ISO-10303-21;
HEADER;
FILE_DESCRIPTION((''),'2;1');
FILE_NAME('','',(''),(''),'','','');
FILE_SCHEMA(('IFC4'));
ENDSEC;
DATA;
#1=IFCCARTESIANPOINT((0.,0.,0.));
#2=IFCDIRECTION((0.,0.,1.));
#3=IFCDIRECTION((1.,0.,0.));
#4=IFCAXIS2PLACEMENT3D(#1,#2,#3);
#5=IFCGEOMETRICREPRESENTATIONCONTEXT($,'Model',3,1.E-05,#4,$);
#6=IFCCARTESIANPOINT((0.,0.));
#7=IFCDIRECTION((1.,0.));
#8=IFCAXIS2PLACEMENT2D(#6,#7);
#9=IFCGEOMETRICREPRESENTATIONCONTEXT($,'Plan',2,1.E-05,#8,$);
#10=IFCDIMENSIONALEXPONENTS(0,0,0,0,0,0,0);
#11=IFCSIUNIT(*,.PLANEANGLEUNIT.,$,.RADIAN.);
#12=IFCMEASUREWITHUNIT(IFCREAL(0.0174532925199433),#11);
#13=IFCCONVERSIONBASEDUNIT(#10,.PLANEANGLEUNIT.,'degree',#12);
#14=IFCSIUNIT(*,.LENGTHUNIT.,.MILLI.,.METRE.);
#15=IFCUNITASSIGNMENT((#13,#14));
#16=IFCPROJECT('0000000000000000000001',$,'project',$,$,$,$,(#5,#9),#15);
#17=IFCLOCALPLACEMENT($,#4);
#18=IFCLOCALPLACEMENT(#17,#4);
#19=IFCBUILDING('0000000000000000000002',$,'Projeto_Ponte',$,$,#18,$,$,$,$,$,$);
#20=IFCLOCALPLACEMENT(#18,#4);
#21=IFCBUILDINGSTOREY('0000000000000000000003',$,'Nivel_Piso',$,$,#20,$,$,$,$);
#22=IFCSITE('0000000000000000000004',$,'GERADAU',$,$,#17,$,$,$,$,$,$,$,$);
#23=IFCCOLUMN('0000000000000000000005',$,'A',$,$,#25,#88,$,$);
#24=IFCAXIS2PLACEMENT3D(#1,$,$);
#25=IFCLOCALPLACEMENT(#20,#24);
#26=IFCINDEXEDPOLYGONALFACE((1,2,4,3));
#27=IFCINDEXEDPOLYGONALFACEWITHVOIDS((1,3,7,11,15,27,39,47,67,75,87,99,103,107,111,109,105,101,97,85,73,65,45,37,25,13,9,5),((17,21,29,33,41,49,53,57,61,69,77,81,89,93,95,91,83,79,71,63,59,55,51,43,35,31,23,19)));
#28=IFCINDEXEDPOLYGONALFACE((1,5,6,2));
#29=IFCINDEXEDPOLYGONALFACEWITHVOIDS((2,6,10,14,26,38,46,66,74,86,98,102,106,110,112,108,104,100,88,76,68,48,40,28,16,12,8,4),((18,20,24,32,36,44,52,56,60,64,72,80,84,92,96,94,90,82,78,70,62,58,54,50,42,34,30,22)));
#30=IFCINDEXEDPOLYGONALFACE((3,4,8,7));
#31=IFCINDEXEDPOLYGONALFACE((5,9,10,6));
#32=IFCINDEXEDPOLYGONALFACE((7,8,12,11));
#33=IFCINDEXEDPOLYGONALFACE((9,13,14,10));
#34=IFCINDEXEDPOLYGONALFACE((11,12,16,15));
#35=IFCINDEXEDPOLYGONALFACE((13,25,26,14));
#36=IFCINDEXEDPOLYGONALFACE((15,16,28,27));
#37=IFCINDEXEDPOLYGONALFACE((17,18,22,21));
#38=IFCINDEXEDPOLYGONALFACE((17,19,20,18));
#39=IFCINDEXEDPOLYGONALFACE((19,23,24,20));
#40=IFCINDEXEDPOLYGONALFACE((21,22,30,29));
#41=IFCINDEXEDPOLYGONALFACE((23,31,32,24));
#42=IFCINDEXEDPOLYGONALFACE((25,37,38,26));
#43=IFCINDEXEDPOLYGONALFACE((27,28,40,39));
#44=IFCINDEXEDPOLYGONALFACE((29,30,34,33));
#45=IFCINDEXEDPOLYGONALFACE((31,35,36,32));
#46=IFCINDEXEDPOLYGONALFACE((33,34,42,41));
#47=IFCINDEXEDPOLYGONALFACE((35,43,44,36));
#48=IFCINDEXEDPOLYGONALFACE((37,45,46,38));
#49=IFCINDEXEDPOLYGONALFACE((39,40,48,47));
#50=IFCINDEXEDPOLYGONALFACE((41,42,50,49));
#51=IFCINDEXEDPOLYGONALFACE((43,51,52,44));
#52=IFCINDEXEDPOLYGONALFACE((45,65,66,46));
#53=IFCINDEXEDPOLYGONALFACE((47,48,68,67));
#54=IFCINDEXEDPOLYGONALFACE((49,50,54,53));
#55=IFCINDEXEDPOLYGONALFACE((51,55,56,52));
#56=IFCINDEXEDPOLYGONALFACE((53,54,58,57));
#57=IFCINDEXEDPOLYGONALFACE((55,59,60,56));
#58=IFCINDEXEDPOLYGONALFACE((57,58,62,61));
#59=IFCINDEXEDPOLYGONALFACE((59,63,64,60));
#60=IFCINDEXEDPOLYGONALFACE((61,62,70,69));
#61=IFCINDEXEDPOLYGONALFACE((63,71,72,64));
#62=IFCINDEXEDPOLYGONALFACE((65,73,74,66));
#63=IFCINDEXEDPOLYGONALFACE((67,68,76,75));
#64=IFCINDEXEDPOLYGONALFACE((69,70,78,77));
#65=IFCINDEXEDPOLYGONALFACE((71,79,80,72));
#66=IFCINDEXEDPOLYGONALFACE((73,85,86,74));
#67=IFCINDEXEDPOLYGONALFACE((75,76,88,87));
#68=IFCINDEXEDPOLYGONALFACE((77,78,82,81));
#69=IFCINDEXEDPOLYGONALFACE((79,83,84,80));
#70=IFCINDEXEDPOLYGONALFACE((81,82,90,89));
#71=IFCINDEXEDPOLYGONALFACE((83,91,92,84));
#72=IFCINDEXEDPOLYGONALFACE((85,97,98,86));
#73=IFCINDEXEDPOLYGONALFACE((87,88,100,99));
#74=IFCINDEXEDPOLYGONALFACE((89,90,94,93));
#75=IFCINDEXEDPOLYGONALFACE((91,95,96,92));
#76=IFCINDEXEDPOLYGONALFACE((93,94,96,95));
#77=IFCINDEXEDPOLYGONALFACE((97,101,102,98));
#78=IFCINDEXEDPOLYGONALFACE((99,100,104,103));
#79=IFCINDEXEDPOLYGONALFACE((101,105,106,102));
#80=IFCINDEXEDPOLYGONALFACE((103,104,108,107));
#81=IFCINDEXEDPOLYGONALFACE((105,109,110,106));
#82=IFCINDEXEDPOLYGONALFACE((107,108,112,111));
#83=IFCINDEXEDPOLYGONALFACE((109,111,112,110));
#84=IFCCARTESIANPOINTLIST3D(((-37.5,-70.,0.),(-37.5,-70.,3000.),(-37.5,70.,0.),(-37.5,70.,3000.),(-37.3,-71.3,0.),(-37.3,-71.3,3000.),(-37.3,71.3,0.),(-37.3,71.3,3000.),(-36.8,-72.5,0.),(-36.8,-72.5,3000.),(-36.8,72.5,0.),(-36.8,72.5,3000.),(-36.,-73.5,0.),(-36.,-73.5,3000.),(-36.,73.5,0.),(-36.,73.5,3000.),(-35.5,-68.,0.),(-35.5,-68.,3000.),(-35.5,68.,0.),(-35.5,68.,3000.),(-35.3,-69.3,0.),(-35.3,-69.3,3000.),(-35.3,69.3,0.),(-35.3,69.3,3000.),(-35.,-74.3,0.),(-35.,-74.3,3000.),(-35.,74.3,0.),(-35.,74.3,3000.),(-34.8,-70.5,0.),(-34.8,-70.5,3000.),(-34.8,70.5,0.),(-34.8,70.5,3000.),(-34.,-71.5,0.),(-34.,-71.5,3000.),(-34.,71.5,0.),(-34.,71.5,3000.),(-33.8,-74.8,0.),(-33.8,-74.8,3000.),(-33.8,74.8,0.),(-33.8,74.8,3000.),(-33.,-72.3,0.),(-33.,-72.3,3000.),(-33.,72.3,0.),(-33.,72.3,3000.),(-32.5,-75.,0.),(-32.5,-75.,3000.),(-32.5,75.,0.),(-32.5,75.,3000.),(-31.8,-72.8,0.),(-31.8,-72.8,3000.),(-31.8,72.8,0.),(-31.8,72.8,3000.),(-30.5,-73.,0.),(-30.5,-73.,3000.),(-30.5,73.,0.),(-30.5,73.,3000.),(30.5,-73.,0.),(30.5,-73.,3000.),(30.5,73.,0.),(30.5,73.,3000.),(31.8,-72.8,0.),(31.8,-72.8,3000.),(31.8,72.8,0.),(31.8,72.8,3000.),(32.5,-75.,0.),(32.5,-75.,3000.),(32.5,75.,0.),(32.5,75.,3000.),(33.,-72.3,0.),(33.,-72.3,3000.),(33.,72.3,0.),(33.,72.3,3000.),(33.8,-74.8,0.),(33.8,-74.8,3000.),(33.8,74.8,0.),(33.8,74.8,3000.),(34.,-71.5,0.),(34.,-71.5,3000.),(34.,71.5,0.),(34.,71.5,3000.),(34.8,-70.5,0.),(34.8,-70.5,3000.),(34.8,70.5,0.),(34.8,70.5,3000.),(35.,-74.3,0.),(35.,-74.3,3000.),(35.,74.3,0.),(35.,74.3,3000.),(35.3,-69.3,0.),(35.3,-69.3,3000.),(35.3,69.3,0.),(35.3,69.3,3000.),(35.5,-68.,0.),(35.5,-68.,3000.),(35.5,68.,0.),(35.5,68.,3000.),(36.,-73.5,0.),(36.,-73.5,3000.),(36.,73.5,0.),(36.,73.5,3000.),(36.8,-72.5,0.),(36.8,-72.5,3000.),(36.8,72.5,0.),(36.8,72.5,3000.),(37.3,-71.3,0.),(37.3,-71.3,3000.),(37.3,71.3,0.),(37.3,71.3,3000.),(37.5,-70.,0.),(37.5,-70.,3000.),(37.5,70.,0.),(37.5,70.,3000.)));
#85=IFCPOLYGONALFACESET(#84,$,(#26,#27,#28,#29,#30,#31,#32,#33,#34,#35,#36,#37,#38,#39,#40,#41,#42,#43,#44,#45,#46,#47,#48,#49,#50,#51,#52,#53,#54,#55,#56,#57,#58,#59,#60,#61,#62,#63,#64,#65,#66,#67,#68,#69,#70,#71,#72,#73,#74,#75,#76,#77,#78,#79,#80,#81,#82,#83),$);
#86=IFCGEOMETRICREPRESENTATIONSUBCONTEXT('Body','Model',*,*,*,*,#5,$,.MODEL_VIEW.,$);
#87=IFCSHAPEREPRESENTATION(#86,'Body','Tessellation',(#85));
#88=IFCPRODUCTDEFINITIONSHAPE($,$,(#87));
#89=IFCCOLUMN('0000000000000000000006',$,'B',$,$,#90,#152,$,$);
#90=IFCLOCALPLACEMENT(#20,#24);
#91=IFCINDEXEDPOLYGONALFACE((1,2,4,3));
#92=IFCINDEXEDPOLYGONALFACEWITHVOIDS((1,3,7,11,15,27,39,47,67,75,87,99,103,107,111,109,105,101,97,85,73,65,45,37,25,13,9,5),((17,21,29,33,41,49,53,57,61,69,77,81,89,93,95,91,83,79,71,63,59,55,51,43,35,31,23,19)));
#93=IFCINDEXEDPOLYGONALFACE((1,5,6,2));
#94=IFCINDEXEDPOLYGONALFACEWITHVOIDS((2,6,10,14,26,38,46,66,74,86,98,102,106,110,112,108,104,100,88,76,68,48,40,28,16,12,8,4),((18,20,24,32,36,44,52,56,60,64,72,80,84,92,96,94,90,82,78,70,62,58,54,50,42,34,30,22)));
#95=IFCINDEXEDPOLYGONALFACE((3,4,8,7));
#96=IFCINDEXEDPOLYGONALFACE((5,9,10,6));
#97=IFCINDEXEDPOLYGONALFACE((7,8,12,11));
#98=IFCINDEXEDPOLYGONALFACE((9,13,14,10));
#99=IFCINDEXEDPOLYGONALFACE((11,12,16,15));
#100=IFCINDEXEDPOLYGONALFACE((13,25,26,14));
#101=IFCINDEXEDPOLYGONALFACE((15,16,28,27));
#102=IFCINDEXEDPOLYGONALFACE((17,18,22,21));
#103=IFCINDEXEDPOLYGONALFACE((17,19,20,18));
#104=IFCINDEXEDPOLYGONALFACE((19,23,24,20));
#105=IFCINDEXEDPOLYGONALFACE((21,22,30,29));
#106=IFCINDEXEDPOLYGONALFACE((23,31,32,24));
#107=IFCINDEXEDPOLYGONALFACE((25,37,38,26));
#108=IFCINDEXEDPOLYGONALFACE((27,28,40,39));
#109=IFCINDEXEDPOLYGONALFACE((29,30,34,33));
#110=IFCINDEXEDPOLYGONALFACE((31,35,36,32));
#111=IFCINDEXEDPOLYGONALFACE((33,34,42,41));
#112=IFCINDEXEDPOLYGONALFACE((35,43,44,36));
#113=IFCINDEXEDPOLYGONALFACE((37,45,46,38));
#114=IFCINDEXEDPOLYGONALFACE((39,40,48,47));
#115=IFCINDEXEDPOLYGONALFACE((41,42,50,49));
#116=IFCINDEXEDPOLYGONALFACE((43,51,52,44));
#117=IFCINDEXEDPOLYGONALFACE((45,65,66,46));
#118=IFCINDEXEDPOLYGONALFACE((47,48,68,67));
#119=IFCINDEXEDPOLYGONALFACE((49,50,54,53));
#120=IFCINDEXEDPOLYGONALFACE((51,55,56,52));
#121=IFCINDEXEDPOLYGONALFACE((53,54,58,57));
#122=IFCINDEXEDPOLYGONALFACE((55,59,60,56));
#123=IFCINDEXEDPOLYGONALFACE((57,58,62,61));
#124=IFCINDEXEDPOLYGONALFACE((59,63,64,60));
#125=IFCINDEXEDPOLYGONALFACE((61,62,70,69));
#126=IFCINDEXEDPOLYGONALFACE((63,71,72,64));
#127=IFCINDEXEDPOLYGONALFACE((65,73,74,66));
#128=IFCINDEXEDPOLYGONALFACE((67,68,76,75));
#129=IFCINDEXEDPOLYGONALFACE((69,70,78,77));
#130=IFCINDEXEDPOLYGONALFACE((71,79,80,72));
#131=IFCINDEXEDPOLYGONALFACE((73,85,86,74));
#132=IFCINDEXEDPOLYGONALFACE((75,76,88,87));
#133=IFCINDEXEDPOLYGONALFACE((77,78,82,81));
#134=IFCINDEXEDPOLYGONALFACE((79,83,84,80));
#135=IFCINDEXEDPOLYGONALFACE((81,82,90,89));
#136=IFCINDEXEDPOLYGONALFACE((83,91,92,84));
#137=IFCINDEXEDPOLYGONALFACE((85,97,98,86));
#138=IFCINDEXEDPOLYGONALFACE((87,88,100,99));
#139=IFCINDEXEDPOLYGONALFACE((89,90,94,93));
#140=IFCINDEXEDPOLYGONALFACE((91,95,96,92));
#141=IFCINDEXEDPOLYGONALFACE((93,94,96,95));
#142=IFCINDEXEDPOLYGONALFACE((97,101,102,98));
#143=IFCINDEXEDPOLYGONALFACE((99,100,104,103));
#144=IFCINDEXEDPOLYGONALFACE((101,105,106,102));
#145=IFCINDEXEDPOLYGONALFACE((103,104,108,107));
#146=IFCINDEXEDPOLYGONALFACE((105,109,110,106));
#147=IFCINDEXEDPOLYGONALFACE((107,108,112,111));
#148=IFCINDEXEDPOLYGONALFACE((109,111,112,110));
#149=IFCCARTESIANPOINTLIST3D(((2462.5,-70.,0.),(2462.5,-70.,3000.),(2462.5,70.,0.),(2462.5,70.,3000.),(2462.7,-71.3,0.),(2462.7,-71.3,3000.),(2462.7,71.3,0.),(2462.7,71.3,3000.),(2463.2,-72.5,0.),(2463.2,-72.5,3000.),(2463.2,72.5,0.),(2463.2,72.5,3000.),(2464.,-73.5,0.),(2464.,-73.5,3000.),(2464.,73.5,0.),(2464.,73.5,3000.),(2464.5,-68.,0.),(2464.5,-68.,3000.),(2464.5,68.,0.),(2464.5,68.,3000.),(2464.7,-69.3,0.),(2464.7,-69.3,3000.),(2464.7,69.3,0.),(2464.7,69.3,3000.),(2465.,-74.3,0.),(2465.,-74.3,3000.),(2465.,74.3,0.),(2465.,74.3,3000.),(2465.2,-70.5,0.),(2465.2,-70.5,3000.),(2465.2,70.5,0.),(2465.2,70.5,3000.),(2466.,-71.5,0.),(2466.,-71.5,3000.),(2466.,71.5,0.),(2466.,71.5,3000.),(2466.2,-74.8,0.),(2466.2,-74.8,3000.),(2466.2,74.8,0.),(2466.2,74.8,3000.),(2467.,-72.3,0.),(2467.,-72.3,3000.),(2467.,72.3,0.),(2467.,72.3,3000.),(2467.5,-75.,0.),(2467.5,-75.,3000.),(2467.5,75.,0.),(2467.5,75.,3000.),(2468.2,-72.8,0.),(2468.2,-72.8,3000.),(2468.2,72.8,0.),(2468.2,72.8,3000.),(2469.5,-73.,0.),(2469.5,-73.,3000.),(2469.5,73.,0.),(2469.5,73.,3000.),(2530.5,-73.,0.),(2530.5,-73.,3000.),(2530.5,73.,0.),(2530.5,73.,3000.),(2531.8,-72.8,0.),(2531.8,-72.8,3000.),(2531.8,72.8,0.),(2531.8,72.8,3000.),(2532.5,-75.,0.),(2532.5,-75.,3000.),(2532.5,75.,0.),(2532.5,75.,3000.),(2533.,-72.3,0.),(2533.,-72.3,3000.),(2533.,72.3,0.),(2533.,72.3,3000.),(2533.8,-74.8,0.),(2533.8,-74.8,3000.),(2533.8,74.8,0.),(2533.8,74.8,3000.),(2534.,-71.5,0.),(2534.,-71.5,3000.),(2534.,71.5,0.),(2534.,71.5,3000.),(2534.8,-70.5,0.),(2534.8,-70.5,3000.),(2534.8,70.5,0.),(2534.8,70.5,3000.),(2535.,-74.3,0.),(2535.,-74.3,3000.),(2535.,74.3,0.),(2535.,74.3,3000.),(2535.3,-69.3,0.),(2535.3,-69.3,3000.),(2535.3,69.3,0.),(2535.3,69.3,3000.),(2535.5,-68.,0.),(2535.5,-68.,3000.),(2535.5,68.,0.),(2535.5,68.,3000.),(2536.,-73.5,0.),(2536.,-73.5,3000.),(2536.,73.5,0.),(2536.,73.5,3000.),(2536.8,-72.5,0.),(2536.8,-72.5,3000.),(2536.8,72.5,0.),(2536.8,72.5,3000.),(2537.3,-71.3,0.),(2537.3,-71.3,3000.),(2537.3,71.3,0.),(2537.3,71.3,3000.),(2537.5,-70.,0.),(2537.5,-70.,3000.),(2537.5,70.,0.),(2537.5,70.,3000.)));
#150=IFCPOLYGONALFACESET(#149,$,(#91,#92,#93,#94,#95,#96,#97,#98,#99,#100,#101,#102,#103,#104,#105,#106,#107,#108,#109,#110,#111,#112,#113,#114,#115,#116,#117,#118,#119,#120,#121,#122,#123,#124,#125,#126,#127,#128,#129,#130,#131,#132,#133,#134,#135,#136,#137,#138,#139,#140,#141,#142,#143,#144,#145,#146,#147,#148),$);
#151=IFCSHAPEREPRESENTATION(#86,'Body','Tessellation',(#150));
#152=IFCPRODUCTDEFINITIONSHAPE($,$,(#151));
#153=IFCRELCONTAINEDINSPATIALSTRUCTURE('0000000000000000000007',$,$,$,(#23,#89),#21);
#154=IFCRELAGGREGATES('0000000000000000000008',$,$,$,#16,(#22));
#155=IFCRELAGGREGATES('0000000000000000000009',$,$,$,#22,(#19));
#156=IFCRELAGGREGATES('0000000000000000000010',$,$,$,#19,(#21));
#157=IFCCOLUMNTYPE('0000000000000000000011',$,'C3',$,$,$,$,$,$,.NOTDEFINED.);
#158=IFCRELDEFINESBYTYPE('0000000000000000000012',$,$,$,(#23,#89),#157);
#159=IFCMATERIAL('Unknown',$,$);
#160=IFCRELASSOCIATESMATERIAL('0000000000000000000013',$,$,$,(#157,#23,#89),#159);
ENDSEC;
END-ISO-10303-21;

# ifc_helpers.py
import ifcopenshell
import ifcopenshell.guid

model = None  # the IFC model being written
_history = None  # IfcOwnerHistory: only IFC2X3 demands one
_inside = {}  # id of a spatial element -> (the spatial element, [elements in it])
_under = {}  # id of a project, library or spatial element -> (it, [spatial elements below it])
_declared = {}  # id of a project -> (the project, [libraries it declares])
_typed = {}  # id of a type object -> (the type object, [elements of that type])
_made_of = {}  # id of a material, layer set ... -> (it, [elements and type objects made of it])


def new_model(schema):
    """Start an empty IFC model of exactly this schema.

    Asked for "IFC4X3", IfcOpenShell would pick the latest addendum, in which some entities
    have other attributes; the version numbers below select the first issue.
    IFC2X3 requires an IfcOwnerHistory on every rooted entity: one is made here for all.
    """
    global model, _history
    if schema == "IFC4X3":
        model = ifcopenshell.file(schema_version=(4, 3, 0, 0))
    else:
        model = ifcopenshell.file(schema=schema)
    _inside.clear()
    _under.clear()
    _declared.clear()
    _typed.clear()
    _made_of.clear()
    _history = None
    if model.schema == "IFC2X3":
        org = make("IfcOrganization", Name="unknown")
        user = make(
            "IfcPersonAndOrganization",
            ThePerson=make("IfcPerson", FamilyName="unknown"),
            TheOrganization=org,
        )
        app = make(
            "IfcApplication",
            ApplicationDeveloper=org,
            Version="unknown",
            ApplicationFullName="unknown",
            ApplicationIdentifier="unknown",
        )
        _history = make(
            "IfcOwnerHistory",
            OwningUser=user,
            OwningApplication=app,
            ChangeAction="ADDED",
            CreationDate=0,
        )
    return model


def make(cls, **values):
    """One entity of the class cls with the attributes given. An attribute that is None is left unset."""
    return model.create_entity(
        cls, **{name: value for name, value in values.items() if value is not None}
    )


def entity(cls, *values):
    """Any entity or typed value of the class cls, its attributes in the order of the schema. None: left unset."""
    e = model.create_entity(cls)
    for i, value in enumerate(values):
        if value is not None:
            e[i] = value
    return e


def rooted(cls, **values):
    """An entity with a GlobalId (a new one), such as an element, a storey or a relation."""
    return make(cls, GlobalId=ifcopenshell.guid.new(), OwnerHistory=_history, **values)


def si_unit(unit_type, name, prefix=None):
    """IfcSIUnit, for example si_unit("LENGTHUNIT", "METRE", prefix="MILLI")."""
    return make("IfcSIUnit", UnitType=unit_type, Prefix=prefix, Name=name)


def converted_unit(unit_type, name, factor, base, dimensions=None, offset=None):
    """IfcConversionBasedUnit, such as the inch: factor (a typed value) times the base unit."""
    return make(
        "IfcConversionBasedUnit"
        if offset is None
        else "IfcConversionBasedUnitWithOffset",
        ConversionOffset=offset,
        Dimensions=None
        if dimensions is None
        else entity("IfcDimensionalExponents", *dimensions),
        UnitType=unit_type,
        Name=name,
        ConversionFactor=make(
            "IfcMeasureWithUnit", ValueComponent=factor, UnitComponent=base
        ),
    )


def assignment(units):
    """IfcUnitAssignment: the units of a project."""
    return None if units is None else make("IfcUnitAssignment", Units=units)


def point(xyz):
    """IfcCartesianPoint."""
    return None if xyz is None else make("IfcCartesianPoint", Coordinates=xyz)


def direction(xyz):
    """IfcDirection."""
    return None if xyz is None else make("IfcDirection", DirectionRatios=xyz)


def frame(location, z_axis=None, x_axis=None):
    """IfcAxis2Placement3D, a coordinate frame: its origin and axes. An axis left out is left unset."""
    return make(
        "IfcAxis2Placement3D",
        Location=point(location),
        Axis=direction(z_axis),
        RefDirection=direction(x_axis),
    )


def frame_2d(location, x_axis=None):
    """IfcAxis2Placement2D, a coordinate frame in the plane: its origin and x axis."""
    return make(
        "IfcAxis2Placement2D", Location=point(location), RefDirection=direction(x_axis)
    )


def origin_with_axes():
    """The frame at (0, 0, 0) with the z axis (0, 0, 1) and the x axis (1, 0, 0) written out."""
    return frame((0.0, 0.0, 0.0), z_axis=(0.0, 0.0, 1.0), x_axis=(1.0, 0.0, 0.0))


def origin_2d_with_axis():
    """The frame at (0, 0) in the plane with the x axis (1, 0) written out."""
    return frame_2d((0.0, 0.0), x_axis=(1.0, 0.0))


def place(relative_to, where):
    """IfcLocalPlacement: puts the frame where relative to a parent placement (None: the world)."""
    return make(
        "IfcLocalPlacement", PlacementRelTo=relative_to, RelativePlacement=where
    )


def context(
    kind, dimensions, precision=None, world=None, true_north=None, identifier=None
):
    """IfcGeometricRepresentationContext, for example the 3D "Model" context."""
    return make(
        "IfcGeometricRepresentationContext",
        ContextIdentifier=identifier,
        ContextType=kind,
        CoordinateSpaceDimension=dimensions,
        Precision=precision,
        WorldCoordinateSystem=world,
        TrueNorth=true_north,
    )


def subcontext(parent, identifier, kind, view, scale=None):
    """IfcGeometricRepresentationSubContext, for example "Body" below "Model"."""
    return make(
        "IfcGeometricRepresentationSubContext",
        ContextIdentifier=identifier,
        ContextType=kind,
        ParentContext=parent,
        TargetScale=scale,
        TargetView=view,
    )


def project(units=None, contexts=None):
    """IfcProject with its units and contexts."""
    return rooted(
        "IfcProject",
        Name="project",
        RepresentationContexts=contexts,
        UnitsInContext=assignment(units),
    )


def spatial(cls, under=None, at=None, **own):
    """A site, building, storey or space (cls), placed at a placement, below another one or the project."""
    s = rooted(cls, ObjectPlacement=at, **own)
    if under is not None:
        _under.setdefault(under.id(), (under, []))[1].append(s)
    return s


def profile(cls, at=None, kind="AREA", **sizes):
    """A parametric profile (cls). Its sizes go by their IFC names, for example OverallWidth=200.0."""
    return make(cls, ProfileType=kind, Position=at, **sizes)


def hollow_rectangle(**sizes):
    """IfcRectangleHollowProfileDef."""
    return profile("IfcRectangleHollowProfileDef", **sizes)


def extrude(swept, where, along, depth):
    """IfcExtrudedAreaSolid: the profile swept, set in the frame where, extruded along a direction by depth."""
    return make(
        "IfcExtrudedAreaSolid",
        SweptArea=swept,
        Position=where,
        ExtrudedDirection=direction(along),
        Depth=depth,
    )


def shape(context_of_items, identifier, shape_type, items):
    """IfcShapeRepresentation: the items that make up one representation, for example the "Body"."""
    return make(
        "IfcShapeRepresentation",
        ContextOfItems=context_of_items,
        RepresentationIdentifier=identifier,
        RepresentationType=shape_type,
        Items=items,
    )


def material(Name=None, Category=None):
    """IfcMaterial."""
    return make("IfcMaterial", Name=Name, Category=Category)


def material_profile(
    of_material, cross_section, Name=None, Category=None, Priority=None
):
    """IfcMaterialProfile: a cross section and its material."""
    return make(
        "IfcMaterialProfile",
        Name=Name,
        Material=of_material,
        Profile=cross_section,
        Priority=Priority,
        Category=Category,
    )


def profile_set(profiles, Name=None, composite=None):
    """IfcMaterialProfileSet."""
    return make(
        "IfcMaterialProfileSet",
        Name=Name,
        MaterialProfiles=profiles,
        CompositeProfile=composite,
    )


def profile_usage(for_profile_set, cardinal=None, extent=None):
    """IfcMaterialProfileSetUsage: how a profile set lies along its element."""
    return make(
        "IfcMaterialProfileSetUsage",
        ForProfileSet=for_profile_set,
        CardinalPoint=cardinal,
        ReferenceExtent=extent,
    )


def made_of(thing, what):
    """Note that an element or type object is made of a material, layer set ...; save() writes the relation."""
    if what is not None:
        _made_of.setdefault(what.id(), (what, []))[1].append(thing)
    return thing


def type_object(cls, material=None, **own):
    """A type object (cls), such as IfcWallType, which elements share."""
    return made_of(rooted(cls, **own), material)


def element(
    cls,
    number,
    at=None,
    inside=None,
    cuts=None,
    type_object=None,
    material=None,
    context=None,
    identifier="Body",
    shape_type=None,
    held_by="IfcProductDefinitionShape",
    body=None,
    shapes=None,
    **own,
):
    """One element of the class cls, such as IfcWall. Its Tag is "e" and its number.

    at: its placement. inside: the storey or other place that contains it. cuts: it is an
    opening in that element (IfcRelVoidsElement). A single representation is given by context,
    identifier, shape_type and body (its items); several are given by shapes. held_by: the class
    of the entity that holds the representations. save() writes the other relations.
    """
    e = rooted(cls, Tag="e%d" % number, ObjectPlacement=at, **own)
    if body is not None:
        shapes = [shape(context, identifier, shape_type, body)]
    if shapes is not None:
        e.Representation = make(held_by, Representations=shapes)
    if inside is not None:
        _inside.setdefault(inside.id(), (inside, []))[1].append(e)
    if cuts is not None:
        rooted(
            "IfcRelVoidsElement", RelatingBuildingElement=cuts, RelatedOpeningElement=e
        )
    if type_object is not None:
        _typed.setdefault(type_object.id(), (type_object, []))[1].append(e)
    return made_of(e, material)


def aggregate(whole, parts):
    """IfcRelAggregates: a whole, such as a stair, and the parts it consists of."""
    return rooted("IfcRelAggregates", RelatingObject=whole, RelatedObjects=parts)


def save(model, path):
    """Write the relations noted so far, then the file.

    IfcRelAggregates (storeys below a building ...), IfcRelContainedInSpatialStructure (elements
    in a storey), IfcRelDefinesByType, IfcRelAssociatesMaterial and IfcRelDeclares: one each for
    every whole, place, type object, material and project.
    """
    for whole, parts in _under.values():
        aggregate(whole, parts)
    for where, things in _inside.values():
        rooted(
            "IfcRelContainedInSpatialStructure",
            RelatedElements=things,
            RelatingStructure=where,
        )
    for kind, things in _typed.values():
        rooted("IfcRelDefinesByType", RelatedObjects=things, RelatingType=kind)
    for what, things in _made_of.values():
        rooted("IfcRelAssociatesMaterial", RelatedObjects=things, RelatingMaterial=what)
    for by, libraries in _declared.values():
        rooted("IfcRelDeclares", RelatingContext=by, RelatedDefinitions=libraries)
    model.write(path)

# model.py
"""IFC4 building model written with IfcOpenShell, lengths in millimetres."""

from ifc_helpers import new_model, entity, si_unit, converted_unit, frame, origin_with_axes, origin_2d_with_axis, place, context, subcontext, project, spatial, hollow_rectangle, extrude, material, material_profile, profile_set, profile_usage, type_object, element, save


model = new_model("IFC4")

# Units and contexts
model_context = context("Model", 3, precision=1e-05, world=origin_with_axes())
plan_context = context("Plan", 2, precision=1e-05, world=origin_2d_with_axis())
body_context = subcontext(model_context, "Body", "Model", "MODEL_VIEW")
ifc_project = project(units=[converted_unit("PLANEANGLEUNIT", "degree", entity("IfcReal", 0.0174532925199433), si_unit("PLANEANGLEUNIT", "RADIAN"), dimensions=[0, 0, 0, 0, 0, 0, 0]), si_unit("LENGTHUNIT", "METRE", prefix="MILLI")], contexts=[model_context, plan_context])

# Site, building, storey
site_placement = place(None, origin_with_axes())
site = spatial("IfcSite", under=ifc_project, at=site_placement, Name="GERADAU")
building_placement = place(site_placement, origin_with_axes())
building = spatial("IfcBuilding", under=site, at=building_placement, Name="Projeto_Ponte")
storey_placement = place(building_placement, origin_with_axes())
storey = spatial("IfcBuildingStorey", under=building, at=storey_placement, Name="Nivel_Piso")

# Columns
ifc_material = material(Name="Unknown")
ifc_material_profile_1 = material_profile(ifc_material, hollow_rectangle(XDim=75.0, YDim=150.0, WallThickness=2.0, InnerFilletRadius=5.0, OuterFilletRadius=5.0))
ifc_profile_set_1 = profile_set([ifc_material_profile_1])
ifc_profile_usage_1 = profile_usage(ifc_profile_set_1, cardinal=5)
column_type = type_object("IfcColumnType", Name="C3", PredefinedType="NOTDEFINED", material=ifc_profile_set_1)
column_1_placement = place(storey_placement, origin_with_axes())
element("IfcColumn", 1, at=column_1_placement, inside=storey, type_object=column_type, material=ifc_profile_usage_1, Name="A", context=body_context, shape_type="SweptSolid", body=[
    extrude(hollow_rectangle(XDim=75.0, YDim=150.0, WallThickness=2.0, InnerFilletRadius=5.0, OuterFilletRadius=5.0), origin_with_axes(), (0.0, 0.0, 1.0), 3000.0),
])
ifc_profile_usage_2 = profile_usage(ifc_profile_set_1, cardinal=5)
column_2_placement = place(storey_placement, frame((2500.0, 0.0, 0.0), z_axis=(0.0, 0.0, 1.0), x_axis=(1.0, 0.0, 0.0)))
element("IfcColumn", 2, at=column_2_placement, inside=storey, type_object=column_type, material=ifc_profile_usage_2, Name="B", context=body_context, shape_type="SweptSolid", body=[
    extrude(hollow_rectangle(XDim=75.0, YDim=150.0, WallThickness=2.0, InnerFilletRadius=5.0, OuterFilletRadius=5.0), origin_with_axes(), (0.0, 0.0, 1.0), 3000.0),
])

save(model, "model.ifc")
